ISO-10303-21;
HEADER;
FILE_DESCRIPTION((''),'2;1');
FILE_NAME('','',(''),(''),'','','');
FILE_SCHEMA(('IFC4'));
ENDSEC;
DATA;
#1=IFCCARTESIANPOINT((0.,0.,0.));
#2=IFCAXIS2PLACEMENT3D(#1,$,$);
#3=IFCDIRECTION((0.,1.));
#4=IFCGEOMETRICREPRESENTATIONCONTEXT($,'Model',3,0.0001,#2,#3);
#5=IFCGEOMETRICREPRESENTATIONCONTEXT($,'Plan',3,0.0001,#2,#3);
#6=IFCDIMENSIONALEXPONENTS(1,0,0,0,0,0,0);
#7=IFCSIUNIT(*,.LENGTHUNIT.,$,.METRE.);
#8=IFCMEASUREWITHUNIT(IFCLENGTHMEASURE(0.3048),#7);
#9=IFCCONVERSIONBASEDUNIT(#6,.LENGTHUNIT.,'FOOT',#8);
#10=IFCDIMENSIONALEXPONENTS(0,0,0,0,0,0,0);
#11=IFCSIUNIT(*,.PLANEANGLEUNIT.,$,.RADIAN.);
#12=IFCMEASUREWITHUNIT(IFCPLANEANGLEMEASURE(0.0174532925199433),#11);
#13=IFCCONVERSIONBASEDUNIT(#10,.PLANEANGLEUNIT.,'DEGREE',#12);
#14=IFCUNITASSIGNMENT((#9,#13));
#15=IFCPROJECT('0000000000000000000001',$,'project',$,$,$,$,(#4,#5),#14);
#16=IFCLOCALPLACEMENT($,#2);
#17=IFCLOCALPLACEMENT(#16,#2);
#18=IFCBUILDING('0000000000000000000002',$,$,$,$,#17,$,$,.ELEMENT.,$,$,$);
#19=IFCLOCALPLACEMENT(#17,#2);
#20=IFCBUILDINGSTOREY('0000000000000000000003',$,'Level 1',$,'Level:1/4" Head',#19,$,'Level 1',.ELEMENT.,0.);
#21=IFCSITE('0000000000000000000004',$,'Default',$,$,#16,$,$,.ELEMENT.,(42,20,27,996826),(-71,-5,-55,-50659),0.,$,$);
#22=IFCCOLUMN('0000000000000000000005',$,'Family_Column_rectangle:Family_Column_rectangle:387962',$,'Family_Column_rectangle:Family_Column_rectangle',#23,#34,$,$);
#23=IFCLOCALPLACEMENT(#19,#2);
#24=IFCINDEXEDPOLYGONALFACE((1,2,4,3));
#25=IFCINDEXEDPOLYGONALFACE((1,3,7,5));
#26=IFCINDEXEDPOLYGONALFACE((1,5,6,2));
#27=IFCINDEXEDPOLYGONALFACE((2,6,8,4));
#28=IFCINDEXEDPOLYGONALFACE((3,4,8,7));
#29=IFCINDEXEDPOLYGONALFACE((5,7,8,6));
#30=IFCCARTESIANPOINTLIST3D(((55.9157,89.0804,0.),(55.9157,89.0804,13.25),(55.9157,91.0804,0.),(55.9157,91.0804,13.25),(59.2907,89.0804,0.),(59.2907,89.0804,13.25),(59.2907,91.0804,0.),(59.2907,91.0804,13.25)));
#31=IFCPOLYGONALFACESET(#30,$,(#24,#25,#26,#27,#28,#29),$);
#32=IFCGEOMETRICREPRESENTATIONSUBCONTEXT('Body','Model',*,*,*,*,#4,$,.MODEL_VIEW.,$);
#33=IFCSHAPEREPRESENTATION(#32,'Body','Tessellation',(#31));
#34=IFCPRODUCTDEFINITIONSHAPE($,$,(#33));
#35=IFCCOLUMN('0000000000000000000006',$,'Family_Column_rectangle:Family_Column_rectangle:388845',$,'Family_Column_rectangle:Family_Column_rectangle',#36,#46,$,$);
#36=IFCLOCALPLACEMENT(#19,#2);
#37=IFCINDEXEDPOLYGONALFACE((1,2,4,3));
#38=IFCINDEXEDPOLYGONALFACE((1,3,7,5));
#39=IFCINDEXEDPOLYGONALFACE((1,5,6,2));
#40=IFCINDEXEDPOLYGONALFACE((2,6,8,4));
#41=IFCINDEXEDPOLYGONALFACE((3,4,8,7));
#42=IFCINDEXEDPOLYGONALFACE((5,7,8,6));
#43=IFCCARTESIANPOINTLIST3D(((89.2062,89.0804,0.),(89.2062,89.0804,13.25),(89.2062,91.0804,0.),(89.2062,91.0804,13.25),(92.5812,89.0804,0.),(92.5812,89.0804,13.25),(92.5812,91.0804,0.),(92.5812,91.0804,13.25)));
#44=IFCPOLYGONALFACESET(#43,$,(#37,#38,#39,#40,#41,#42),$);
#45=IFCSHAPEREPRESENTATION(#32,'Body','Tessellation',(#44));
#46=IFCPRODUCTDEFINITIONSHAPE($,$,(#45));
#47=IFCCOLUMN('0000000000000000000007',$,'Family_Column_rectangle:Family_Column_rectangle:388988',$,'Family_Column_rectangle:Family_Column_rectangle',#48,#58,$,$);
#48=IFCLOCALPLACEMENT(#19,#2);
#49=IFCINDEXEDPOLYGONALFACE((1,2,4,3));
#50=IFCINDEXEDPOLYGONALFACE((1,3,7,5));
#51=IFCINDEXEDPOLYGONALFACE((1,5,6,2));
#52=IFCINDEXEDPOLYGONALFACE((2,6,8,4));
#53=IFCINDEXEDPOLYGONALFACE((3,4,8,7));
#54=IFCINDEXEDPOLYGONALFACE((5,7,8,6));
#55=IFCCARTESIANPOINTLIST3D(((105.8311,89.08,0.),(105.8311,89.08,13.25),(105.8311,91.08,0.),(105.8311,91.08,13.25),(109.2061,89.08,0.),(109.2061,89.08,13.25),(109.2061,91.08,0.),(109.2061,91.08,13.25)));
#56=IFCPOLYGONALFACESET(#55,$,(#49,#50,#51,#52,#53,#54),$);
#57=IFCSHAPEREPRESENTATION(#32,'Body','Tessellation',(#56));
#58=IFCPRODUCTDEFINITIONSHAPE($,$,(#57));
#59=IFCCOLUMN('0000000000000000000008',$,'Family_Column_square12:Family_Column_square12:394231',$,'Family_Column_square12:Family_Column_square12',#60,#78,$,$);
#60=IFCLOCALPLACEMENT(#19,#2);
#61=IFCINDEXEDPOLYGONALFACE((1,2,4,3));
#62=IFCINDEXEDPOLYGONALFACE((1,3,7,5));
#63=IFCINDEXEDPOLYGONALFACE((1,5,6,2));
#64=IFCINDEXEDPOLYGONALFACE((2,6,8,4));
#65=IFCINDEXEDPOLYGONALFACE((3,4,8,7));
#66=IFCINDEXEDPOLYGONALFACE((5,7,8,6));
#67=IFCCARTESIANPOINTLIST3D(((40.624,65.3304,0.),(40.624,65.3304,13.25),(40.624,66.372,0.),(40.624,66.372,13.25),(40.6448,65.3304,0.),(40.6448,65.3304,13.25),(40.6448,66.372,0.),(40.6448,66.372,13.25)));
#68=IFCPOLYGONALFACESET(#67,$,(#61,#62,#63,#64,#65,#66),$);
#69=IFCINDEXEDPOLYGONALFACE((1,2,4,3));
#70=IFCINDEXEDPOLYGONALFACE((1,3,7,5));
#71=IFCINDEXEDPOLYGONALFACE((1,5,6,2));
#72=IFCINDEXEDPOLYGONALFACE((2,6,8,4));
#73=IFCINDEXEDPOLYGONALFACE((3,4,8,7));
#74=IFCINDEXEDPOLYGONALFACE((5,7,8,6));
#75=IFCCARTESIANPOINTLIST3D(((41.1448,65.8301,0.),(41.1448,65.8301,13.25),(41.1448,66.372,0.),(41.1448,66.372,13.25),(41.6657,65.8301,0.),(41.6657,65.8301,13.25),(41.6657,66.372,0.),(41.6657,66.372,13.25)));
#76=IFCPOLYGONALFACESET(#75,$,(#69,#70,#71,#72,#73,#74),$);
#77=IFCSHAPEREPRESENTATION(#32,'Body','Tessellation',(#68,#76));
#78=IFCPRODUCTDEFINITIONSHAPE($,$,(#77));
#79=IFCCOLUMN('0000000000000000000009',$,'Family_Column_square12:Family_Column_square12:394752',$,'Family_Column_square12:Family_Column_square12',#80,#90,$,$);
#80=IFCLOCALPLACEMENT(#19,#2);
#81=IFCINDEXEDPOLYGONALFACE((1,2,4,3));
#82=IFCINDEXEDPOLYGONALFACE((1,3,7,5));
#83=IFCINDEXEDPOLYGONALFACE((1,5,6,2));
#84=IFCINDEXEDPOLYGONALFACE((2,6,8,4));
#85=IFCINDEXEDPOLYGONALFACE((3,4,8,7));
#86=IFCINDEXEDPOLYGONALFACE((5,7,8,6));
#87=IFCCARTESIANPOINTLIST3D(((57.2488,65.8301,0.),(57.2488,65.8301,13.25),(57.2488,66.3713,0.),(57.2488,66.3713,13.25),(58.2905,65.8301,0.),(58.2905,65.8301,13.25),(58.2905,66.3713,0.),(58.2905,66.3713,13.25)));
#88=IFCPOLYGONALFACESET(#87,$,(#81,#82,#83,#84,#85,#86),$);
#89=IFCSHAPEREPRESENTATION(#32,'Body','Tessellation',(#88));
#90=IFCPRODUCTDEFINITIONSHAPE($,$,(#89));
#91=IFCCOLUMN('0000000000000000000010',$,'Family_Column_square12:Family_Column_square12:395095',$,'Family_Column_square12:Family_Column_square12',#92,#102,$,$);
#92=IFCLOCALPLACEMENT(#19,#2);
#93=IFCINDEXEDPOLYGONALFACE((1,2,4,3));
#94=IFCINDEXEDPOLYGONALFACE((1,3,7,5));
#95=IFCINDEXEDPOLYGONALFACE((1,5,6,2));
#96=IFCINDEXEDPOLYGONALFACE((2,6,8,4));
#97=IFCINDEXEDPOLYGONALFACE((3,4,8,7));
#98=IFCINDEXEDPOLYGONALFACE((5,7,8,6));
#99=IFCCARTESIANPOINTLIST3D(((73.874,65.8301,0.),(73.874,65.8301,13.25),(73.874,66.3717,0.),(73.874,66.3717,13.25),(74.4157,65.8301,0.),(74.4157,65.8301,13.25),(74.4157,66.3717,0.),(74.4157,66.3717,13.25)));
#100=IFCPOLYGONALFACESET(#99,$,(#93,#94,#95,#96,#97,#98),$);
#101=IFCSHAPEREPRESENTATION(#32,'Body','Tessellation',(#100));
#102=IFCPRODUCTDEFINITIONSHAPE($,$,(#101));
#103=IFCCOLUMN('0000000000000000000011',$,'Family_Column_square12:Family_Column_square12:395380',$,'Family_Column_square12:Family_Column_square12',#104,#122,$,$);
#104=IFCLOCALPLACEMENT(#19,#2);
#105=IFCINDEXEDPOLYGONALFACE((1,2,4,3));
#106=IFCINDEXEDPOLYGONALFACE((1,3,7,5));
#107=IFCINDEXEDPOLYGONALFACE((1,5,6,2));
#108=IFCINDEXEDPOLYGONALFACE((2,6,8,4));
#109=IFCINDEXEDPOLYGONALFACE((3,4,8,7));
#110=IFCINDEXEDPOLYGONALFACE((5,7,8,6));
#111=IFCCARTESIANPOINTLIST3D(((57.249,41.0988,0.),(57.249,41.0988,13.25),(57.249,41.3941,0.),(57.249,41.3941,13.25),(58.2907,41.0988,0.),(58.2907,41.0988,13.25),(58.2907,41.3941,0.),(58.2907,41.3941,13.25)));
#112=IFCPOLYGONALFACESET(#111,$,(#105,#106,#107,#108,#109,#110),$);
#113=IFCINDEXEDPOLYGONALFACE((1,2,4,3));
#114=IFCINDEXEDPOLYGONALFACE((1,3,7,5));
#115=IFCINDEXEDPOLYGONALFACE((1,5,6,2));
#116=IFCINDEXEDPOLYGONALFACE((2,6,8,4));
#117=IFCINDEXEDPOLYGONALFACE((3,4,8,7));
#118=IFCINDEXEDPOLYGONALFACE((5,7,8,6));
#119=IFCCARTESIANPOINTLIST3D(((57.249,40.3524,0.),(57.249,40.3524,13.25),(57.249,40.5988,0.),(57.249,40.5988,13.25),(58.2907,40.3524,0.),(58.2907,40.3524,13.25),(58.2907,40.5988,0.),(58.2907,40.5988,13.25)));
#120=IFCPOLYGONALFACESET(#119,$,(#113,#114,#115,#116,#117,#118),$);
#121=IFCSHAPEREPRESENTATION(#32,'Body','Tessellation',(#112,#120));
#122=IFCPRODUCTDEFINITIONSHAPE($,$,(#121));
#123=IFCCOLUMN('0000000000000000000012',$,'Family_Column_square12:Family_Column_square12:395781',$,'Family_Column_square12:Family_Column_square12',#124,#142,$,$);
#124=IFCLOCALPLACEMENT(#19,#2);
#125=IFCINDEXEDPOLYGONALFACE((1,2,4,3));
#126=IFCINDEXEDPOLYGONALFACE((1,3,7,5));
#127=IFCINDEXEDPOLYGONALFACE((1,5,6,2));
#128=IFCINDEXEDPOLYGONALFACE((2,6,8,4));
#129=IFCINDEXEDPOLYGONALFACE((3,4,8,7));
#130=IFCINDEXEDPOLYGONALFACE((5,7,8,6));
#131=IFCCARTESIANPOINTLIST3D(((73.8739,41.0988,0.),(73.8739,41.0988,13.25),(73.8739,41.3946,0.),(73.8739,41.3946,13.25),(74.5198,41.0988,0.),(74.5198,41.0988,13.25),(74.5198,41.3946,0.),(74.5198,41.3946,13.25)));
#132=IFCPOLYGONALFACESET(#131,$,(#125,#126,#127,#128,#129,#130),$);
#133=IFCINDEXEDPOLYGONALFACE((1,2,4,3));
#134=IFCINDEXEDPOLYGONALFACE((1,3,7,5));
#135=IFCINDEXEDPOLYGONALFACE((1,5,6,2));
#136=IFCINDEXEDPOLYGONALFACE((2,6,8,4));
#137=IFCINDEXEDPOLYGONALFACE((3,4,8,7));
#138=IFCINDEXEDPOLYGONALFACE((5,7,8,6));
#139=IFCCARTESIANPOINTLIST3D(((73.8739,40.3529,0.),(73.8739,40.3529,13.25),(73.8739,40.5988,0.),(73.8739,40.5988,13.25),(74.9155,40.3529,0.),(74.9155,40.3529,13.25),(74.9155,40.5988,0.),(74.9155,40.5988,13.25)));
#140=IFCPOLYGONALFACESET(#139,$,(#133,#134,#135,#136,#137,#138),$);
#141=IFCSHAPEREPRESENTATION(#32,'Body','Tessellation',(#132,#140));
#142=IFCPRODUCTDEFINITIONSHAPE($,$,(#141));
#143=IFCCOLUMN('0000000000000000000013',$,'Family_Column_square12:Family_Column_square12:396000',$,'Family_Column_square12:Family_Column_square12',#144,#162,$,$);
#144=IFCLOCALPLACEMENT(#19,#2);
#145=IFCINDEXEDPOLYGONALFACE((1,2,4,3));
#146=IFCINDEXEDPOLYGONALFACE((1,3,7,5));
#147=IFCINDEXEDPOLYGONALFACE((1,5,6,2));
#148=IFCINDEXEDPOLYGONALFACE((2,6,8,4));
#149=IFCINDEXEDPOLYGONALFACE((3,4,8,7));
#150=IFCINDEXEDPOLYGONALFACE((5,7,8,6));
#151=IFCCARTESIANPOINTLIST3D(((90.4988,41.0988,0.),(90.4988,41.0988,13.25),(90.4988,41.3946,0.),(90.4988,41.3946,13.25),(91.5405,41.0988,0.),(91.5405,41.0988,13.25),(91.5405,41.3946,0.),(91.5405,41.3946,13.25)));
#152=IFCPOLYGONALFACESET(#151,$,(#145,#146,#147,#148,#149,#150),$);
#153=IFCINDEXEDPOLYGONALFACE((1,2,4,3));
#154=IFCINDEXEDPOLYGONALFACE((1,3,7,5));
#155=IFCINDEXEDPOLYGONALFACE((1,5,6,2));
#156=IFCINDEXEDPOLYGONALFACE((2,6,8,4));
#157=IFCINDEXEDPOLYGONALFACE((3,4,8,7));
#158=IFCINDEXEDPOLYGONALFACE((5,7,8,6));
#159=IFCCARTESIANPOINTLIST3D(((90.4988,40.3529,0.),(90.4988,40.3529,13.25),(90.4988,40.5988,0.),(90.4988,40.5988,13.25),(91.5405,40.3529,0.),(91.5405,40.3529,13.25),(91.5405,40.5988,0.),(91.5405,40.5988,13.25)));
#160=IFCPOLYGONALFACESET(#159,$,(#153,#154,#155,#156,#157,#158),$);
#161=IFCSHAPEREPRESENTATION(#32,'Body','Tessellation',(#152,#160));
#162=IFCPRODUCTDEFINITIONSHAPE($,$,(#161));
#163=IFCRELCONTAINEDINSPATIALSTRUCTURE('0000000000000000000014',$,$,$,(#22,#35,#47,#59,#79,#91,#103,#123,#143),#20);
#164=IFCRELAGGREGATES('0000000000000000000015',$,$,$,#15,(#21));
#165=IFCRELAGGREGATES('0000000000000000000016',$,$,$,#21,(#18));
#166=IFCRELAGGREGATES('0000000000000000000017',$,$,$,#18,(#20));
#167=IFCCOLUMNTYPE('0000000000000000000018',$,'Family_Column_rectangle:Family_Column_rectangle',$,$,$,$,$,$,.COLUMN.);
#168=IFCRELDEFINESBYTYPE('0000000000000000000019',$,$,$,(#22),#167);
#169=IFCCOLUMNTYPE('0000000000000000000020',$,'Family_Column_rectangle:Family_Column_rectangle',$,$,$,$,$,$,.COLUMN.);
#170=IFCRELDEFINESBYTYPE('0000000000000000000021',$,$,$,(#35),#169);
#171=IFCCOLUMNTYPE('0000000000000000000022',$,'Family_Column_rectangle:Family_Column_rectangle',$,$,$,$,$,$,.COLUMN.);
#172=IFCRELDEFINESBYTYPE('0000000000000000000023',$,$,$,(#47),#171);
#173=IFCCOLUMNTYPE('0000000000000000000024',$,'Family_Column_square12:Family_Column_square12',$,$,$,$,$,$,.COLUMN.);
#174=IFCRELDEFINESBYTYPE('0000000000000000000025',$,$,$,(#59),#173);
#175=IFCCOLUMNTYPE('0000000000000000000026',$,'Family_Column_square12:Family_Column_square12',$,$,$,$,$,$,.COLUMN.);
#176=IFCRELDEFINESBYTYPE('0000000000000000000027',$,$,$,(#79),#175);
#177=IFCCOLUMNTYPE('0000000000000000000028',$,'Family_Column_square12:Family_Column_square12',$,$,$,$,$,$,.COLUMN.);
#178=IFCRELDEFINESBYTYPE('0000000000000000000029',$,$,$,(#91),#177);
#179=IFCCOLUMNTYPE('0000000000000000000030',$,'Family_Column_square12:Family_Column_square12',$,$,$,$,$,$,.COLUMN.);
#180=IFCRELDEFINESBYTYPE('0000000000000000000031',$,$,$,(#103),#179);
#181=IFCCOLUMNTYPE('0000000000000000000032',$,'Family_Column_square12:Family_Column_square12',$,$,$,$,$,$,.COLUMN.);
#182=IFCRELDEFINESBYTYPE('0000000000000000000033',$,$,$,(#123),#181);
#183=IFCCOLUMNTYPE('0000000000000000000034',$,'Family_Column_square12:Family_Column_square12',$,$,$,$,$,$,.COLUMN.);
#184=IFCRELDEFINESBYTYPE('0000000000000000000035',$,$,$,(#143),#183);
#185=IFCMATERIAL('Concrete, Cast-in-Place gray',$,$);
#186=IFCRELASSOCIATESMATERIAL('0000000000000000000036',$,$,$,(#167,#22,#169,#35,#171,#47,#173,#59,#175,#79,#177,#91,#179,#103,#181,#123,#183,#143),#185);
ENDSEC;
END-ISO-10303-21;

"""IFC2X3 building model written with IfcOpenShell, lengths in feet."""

from ifc_helpers import new_model, entity, si_unit, converted_unit, direction, frame, frame_2d, origin, origin_2d_with_axis, place, context, subcontext, project, spatial, rectangle, extrude, source, transform, mapped, material, type_object, type_shapes, element, save


model = new_model("IFC2X3")

# Units and contexts
model_context = context("Model", 3, precision=0.0001, world=origin(), true_north=direction((0.0, 1.0)))
plan_context = context("Plan", 3, precision=0.0001, world=origin(), true_north=direction((0.0, 1.0)))
body_context = subcontext(model_context, "Body", "Model", "MODEL_VIEW")
ifc_project = project(units=[converted_unit("LENGTHUNIT", "FOOT", entity("IfcLengthMeasure", 0.3048), si_unit("LENGTHUNIT", "METRE"), dimensions=[1, 0, 0, 0, 0, 0, 0]), converted_unit("PLANEANGLEUNIT", "DEGREE", entity("IfcPlaneAngleMeasure", 0.0174532925199433), si_unit("PLANEANGLEUNIT", "RADIAN"), dimensions=[0, 0, 0, 0, 0, 0, 0])], contexts=[model_context, plan_context])

# Site, building, storey
site_placement = place(None, origin())
site = spatial("IfcSite", under=ifc_project, at=site_placement, Name="Default", CompositionType="ELEMENT", RefLatitude=(42, 20, 27, 996826), RefLongitude=(-71, -5, -55, -50659), RefElevation=0.0)
building_placement = place(site_placement, origin())
building = spatial("IfcBuilding", under=site, at=building_placement, CompositionType="ELEMENT")
storey_placement = place(building_placement, origin())
storey = spatial("IfcBuildingStorey", under=building, at=storey_placement, Name="Level 1", ObjectType="Level:1/4\" Head", LongName="Level 1", CompositionType="ELEMENT", Elevation=0.0)

# Columns
ifc_material_1 = material(Name="Concrete, Cast-in-Place gray")
column_type_1 = type_object("IfcColumnType", Name="Family_Column_rectangle:Family_Column_rectangle", PredefinedType="COLUMN", material=ifc_material_1)
shared_shape_1 = source(origin(), body_context, "Body", "SweptSolid", [
    extrude(rectangle(XDim=3.375, YDim=2.0, at=frame_2d((0.0, 0.0), x_axis=(1.0, 0.0))), frame((57.6032, 90.0804, 0.0), z_axis=(0.0, 0.0, 1.0), x_axis=(-1.0, 0.0, 0.0)), (0.0, 0.0, 1.0), 13.25),
])
type_shapes(column_type_1, [shared_shape_1])
column_1_placement = place(storey_placement, origin())
element("IfcColumn", 1, at=column_1_placement, inside=storey, type_object=column_type_1, material=ifc_material_1, Name="Family_Column_rectangle:Family_Column_rectangle:387962", ObjectType="Family_Column_rectangle:Family_Column_rectangle", context=body_context, shape_type="MappedRepresentation", body=[
    mapped(shared_shape_1, transform((0.0, 0.0, 0.0), scale=1.0)),
])
column_type_2 = type_object("IfcColumnType", Name="Family_Column_rectangle:Family_Column_rectangle", PredefinedType="COLUMN", material=ifc_material_1)
shared_shape_2 = source(origin(), body_context, "Body", "SweptSolid", [
    extrude(rectangle(XDim=3.375, YDim=2.0, at=frame_2d((0.0, 0.0), x_axis=(1.0, 0.0))), frame((90.8937, 90.0804, 0.0), z_axis=(0.0, 0.0, 1.0), x_axis=(-1.0, 0.0, 0.0)), (0.0, 0.0, 1.0), 13.25),
])
type_shapes(column_type_2, [shared_shape_2])
column_2_placement = place(storey_placement, origin())
element("IfcColumn", 2, at=column_2_placement, inside=storey, type_object=column_type_2, material=ifc_material_1, Name="Family_Column_rectangle:Family_Column_rectangle:388845", ObjectType="Family_Column_rectangle:Family_Column_rectangle", context=body_context, shape_type="MappedRepresentation", body=[
    mapped(shared_shape_2, transform((0.0, 0.0, 0.0), scale=1.0)),
])
column_type_3 = type_object("IfcColumnType", Name="Family_Column_rectangle:Family_Column_rectangle", PredefinedType="COLUMN", material=ifc_material_1)
shared_shape_3 = source(origin(), body_context, "Body", "SweptSolid", [
    extrude(rectangle(XDim=3.375, YDim=2.0, at=frame_2d((0.0, 0.0), x_axis=(1.0, 0.0))), frame((107.5186, 90.08, 0.0), z_axis=(0.0, 0.0, 1.0), x_axis=(-1.0, 0.0, 0.0)), (0.0, 0.0, 1.0), 13.25),
])
type_shapes(column_type_3, [shared_shape_3])
column_3_placement = place(storey_placement, origin())
element("IfcColumn", 3, at=column_3_placement, inside=storey, type_object=column_type_3, material=ifc_material_1, Name="Family_Column_rectangle:Family_Column_rectangle:388988", ObjectType="Family_Column_rectangle:Family_Column_rectangle", context=body_context, shape_type="MappedRepresentation", body=[
    mapped(shared_shape_3, transform((0.0, 0.0, 0.0), scale=1.0)),
])
column_type_4 = type_object("IfcColumnType", Name="Family_Column_square12:Family_Column_square12", PredefinedType="COLUMN", material=ifc_material_1)
shared_shape_4 = source(origin(), body_context, "Body", "SweptSolid", [
    extrude(rectangle(XDim=0.0208, YDim=1.0417, at=frame_2d((0.0, 0.0), x_axis=(1.0, 0.0))), frame((40.6344, 65.8512, 0.0)), (0.0, 0.0, 1.0), 13.25),
    extrude(rectangle(XDim=0.5208, YDim=0.5419, at=origin_2d_with_axis()), frame((41.4052, 66.1011, 0.0), z_axis=(0.0, 0.0, 1.0), x_axis=(-1.0, 0.0, 0.0)), (0.0, 0.0, 1.0), 13.25),
])
type_shapes(column_type_4, [shared_shape_4])
column_4_placement = place(storey_placement, origin())
element("IfcColumn", 4, at=column_4_placement, inside=storey, type_object=column_type_4, material=ifc_material_1, Name="Family_Column_square12:Family_Column_square12:394231", ObjectType="Family_Column_square12:Family_Column_square12", context=body_context, shape_type="MappedRepresentation", body=[
    mapped(shared_shape_4, transform((0.0, 0.0, 0.0), scale=1.0)),
])
column_type_5 = type_object("IfcColumnType", Name="Family_Column_square12:Family_Column_square12", PredefinedType="COLUMN", material=ifc_material_1)
shared_shape_5 = source(origin(), body_context, "Body", "SweptSolid", [
    extrude(rectangle(XDim=0.5412, YDim=1.0417, at=frame_2d((0.0, 0.0), x_axis=(1.0, 0.0))), frame((57.7696, 66.1007, 0.0), z_axis=(0.0, 0.0, 1.0), x_axis=(0.0, -1.0, 0.0)), (0.0, 0.0, 1.0), 13.25),
])
type_shapes(column_type_5, [shared_shape_5])
column_5_placement = place(storey_placement, origin())
element("IfcColumn", 5, at=column_5_placement, inside=storey, type_object=column_type_5, material=ifc_material_1, Name="Family_Column_square12:Family_Column_square12:394752", ObjectType="Family_Column_square12:Family_Column_square12", context=body_context, shape_type="MappedRepresentation", body=[
    mapped(shared_shape_5, transform((0.0, 0.0, 0.0), scale=1.0)),
])
column_type_6 = type_object("IfcColumnType", Name="Family_Column_square12:Family_Column_square12", PredefinedType="COLUMN", material=ifc_material_1)
shared_shape_6 = source(origin(), body_context, "Body", "SweptSolid", [
    extrude(rectangle(XDim=0.5417, YDim=0.5416, at=frame_2d((0.0, 0.0), x_axis=(1.0, 0.0))), frame((74.1448, 66.1009, 0.0)), (0.0, 0.0, 1.0), 13.25),
])
type_shapes(column_type_6, [shared_shape_6])
column_6_placement = place(storey_placement, origin())
element("IfcColumn", 6, at=column_6_placement, inside=storey, type_object=column_type_6, material=ifc_material_1, Name="Family_Column_square12:Family_Column_square12:395095", ObjectType="Family_Column_square12:Family_Column_square12", context=body_context, shape_type="MappedRepresentation", body=[
    mapped(shared_shape_6, transform((0.0, 0.0, 0.0), scale=1.0)),
])
column_type_7 = type_object("IfcColumnType", Name="Family_Column_square12:Family_Column_square12", PredefinedType="COLUMN", material=ifc_material_1)
shared_shape_7 = source(origin(), body_context, "Body", "SweptSolid", [
    extrude(rectangle(XDim=0.2952, YDim=1.0417, at=frame_2d((0.0, 0.0), x_axis=(1.0, 0.0))), frame((57.7698, 41.2464, 0.0), z_axis=(0.0, 0.0, 1.0), x_axis=(0.0, -1.0, 0.0)), (0.0, 0.0, 1.0), 13.25),
    extrude(rectangle(XDim=0.2464, YDim=1.0417, at=frame_2d((0.0, 0.0), x_axis=(1.0, 0.0))), frame((57.7698, 40.4756, 0.0), z_axis=(0.0, 0.0, 1.0), x_axis=(0.0, 1.0, 0.0)), (0.0, 0.0, 1.0), 13.25),
])
type_shapes(column_type_7, [shared_shape_7])
column_7_placement = place(storey_placement, origin())
element("IfcColumn", 7, at=column_7_placement, inside=storey, type_object=column_type_7, material=ifc_material_1, Name="Family_Column_square12:Family_Column_square12:395380", ObjectType="Family_Column_square12:Family_Column_square12", context=body_context, shape_type="MappedRepresentation", body=[
    mapped(shared_shape_7, transform((0.0, 0.0, 0.0), scale=1.0)),
])
column_type_8 = type_object("IfcColumnType", Name="Family_Column_square12:Family_Column_square12", PredefinedType="COLUMN", material=ifc_material_1)
shared_shape_8 = source(origin(), body_context, "Body", "SweptSolid", [
    extrude(rectangle(XDim=0.2958, YDim=0.646, at=frame_2d((0.0, 0.0), x_axis=(1.0, 0.0))), frame((74.1968, 41.2467, 0.0), z_axis=(0.0, 0.0, 1.0), x_axis=(0.0, -1.0, 0.0)), (0.0, 0.0, 1.0), 13.25),
    extrude(rectangle(XDim=0.2459, YDim=1.0417, at=origin_2d_with_axis()), frame((74.3947, 40.4759, 0.0), z_axis=(0.0, 0.0, 1.0), x_axis=(0.0, 1.0, 0.0)), (0.0, 0.0, 1.0), 13.25),
])
type_shapes(column_type_8, [shared_shape_8])
column_8_placement = place(storey_placement, origin())
element("IfcColumn", 8, at=column_8_placement, inside=storey, type_object=column_type_8, material=ifc_material_1, Name="Family_Column_square12:Family_Column_square12:395781", ObjectType="Family_Column_square12:Family_Column_square12", context=body_context, shape_type="MappedRepresentation", body=[
    mapped(shared_shape_8, transform((0.0, 0.0, 0.0), scale=1.0)),
])
column_type_9 = type_object("IfcColumnType", Name="Family_Column_square12:Family_Column_square12", PredefinedType="COLUMN", material=ifc_material_1)
shared_shape_9 = source(origin(), body_context, "Body", "SweptSolid", [
    extrude(rectangle(XDim=0.2958, YDim=1.0417, at=frame_2d((0.0, 0.0), x_axis=(1.0, 0.0))), frame((91.0197, 41.2467, 0.0), z_axis=(0.0, 0.0, 1.0), x_axis=(0.0, -1.0, 0.0)), (0.0, 0.0, 1.0), 13.25),
    extrude(rectangle(XDim=0.2459, YDim=1.0417, at=origin_2d_with_axis()), frame((91.0197, 40.4759, 0.0), z_axis=(0.0, 0.0, 1.0), x_axis=(0.0, 1.0, 0.0)), (0.0, 0.0, 1.0), 13.25),
])
type_shapes(column_type_9, [shared_shape_9])
column_9_placement = place(storey_placement, origin())
element("IfcColumn", 9, at=column_9_placement, inside=storey, type_object=column_type_9, material=ifc_material_1, Name="Family_Column_square12:Family_Column_square12:396000", ObjectType="Family_Column_square12:Family_Column_square12", context=body_context, shape_type="MappedRepresentation", body=[
    mapped(shared_shape_9, transform((0.0, 0.0, 0.0), scale=1.0)),
])

save(model, "model.ifc")
